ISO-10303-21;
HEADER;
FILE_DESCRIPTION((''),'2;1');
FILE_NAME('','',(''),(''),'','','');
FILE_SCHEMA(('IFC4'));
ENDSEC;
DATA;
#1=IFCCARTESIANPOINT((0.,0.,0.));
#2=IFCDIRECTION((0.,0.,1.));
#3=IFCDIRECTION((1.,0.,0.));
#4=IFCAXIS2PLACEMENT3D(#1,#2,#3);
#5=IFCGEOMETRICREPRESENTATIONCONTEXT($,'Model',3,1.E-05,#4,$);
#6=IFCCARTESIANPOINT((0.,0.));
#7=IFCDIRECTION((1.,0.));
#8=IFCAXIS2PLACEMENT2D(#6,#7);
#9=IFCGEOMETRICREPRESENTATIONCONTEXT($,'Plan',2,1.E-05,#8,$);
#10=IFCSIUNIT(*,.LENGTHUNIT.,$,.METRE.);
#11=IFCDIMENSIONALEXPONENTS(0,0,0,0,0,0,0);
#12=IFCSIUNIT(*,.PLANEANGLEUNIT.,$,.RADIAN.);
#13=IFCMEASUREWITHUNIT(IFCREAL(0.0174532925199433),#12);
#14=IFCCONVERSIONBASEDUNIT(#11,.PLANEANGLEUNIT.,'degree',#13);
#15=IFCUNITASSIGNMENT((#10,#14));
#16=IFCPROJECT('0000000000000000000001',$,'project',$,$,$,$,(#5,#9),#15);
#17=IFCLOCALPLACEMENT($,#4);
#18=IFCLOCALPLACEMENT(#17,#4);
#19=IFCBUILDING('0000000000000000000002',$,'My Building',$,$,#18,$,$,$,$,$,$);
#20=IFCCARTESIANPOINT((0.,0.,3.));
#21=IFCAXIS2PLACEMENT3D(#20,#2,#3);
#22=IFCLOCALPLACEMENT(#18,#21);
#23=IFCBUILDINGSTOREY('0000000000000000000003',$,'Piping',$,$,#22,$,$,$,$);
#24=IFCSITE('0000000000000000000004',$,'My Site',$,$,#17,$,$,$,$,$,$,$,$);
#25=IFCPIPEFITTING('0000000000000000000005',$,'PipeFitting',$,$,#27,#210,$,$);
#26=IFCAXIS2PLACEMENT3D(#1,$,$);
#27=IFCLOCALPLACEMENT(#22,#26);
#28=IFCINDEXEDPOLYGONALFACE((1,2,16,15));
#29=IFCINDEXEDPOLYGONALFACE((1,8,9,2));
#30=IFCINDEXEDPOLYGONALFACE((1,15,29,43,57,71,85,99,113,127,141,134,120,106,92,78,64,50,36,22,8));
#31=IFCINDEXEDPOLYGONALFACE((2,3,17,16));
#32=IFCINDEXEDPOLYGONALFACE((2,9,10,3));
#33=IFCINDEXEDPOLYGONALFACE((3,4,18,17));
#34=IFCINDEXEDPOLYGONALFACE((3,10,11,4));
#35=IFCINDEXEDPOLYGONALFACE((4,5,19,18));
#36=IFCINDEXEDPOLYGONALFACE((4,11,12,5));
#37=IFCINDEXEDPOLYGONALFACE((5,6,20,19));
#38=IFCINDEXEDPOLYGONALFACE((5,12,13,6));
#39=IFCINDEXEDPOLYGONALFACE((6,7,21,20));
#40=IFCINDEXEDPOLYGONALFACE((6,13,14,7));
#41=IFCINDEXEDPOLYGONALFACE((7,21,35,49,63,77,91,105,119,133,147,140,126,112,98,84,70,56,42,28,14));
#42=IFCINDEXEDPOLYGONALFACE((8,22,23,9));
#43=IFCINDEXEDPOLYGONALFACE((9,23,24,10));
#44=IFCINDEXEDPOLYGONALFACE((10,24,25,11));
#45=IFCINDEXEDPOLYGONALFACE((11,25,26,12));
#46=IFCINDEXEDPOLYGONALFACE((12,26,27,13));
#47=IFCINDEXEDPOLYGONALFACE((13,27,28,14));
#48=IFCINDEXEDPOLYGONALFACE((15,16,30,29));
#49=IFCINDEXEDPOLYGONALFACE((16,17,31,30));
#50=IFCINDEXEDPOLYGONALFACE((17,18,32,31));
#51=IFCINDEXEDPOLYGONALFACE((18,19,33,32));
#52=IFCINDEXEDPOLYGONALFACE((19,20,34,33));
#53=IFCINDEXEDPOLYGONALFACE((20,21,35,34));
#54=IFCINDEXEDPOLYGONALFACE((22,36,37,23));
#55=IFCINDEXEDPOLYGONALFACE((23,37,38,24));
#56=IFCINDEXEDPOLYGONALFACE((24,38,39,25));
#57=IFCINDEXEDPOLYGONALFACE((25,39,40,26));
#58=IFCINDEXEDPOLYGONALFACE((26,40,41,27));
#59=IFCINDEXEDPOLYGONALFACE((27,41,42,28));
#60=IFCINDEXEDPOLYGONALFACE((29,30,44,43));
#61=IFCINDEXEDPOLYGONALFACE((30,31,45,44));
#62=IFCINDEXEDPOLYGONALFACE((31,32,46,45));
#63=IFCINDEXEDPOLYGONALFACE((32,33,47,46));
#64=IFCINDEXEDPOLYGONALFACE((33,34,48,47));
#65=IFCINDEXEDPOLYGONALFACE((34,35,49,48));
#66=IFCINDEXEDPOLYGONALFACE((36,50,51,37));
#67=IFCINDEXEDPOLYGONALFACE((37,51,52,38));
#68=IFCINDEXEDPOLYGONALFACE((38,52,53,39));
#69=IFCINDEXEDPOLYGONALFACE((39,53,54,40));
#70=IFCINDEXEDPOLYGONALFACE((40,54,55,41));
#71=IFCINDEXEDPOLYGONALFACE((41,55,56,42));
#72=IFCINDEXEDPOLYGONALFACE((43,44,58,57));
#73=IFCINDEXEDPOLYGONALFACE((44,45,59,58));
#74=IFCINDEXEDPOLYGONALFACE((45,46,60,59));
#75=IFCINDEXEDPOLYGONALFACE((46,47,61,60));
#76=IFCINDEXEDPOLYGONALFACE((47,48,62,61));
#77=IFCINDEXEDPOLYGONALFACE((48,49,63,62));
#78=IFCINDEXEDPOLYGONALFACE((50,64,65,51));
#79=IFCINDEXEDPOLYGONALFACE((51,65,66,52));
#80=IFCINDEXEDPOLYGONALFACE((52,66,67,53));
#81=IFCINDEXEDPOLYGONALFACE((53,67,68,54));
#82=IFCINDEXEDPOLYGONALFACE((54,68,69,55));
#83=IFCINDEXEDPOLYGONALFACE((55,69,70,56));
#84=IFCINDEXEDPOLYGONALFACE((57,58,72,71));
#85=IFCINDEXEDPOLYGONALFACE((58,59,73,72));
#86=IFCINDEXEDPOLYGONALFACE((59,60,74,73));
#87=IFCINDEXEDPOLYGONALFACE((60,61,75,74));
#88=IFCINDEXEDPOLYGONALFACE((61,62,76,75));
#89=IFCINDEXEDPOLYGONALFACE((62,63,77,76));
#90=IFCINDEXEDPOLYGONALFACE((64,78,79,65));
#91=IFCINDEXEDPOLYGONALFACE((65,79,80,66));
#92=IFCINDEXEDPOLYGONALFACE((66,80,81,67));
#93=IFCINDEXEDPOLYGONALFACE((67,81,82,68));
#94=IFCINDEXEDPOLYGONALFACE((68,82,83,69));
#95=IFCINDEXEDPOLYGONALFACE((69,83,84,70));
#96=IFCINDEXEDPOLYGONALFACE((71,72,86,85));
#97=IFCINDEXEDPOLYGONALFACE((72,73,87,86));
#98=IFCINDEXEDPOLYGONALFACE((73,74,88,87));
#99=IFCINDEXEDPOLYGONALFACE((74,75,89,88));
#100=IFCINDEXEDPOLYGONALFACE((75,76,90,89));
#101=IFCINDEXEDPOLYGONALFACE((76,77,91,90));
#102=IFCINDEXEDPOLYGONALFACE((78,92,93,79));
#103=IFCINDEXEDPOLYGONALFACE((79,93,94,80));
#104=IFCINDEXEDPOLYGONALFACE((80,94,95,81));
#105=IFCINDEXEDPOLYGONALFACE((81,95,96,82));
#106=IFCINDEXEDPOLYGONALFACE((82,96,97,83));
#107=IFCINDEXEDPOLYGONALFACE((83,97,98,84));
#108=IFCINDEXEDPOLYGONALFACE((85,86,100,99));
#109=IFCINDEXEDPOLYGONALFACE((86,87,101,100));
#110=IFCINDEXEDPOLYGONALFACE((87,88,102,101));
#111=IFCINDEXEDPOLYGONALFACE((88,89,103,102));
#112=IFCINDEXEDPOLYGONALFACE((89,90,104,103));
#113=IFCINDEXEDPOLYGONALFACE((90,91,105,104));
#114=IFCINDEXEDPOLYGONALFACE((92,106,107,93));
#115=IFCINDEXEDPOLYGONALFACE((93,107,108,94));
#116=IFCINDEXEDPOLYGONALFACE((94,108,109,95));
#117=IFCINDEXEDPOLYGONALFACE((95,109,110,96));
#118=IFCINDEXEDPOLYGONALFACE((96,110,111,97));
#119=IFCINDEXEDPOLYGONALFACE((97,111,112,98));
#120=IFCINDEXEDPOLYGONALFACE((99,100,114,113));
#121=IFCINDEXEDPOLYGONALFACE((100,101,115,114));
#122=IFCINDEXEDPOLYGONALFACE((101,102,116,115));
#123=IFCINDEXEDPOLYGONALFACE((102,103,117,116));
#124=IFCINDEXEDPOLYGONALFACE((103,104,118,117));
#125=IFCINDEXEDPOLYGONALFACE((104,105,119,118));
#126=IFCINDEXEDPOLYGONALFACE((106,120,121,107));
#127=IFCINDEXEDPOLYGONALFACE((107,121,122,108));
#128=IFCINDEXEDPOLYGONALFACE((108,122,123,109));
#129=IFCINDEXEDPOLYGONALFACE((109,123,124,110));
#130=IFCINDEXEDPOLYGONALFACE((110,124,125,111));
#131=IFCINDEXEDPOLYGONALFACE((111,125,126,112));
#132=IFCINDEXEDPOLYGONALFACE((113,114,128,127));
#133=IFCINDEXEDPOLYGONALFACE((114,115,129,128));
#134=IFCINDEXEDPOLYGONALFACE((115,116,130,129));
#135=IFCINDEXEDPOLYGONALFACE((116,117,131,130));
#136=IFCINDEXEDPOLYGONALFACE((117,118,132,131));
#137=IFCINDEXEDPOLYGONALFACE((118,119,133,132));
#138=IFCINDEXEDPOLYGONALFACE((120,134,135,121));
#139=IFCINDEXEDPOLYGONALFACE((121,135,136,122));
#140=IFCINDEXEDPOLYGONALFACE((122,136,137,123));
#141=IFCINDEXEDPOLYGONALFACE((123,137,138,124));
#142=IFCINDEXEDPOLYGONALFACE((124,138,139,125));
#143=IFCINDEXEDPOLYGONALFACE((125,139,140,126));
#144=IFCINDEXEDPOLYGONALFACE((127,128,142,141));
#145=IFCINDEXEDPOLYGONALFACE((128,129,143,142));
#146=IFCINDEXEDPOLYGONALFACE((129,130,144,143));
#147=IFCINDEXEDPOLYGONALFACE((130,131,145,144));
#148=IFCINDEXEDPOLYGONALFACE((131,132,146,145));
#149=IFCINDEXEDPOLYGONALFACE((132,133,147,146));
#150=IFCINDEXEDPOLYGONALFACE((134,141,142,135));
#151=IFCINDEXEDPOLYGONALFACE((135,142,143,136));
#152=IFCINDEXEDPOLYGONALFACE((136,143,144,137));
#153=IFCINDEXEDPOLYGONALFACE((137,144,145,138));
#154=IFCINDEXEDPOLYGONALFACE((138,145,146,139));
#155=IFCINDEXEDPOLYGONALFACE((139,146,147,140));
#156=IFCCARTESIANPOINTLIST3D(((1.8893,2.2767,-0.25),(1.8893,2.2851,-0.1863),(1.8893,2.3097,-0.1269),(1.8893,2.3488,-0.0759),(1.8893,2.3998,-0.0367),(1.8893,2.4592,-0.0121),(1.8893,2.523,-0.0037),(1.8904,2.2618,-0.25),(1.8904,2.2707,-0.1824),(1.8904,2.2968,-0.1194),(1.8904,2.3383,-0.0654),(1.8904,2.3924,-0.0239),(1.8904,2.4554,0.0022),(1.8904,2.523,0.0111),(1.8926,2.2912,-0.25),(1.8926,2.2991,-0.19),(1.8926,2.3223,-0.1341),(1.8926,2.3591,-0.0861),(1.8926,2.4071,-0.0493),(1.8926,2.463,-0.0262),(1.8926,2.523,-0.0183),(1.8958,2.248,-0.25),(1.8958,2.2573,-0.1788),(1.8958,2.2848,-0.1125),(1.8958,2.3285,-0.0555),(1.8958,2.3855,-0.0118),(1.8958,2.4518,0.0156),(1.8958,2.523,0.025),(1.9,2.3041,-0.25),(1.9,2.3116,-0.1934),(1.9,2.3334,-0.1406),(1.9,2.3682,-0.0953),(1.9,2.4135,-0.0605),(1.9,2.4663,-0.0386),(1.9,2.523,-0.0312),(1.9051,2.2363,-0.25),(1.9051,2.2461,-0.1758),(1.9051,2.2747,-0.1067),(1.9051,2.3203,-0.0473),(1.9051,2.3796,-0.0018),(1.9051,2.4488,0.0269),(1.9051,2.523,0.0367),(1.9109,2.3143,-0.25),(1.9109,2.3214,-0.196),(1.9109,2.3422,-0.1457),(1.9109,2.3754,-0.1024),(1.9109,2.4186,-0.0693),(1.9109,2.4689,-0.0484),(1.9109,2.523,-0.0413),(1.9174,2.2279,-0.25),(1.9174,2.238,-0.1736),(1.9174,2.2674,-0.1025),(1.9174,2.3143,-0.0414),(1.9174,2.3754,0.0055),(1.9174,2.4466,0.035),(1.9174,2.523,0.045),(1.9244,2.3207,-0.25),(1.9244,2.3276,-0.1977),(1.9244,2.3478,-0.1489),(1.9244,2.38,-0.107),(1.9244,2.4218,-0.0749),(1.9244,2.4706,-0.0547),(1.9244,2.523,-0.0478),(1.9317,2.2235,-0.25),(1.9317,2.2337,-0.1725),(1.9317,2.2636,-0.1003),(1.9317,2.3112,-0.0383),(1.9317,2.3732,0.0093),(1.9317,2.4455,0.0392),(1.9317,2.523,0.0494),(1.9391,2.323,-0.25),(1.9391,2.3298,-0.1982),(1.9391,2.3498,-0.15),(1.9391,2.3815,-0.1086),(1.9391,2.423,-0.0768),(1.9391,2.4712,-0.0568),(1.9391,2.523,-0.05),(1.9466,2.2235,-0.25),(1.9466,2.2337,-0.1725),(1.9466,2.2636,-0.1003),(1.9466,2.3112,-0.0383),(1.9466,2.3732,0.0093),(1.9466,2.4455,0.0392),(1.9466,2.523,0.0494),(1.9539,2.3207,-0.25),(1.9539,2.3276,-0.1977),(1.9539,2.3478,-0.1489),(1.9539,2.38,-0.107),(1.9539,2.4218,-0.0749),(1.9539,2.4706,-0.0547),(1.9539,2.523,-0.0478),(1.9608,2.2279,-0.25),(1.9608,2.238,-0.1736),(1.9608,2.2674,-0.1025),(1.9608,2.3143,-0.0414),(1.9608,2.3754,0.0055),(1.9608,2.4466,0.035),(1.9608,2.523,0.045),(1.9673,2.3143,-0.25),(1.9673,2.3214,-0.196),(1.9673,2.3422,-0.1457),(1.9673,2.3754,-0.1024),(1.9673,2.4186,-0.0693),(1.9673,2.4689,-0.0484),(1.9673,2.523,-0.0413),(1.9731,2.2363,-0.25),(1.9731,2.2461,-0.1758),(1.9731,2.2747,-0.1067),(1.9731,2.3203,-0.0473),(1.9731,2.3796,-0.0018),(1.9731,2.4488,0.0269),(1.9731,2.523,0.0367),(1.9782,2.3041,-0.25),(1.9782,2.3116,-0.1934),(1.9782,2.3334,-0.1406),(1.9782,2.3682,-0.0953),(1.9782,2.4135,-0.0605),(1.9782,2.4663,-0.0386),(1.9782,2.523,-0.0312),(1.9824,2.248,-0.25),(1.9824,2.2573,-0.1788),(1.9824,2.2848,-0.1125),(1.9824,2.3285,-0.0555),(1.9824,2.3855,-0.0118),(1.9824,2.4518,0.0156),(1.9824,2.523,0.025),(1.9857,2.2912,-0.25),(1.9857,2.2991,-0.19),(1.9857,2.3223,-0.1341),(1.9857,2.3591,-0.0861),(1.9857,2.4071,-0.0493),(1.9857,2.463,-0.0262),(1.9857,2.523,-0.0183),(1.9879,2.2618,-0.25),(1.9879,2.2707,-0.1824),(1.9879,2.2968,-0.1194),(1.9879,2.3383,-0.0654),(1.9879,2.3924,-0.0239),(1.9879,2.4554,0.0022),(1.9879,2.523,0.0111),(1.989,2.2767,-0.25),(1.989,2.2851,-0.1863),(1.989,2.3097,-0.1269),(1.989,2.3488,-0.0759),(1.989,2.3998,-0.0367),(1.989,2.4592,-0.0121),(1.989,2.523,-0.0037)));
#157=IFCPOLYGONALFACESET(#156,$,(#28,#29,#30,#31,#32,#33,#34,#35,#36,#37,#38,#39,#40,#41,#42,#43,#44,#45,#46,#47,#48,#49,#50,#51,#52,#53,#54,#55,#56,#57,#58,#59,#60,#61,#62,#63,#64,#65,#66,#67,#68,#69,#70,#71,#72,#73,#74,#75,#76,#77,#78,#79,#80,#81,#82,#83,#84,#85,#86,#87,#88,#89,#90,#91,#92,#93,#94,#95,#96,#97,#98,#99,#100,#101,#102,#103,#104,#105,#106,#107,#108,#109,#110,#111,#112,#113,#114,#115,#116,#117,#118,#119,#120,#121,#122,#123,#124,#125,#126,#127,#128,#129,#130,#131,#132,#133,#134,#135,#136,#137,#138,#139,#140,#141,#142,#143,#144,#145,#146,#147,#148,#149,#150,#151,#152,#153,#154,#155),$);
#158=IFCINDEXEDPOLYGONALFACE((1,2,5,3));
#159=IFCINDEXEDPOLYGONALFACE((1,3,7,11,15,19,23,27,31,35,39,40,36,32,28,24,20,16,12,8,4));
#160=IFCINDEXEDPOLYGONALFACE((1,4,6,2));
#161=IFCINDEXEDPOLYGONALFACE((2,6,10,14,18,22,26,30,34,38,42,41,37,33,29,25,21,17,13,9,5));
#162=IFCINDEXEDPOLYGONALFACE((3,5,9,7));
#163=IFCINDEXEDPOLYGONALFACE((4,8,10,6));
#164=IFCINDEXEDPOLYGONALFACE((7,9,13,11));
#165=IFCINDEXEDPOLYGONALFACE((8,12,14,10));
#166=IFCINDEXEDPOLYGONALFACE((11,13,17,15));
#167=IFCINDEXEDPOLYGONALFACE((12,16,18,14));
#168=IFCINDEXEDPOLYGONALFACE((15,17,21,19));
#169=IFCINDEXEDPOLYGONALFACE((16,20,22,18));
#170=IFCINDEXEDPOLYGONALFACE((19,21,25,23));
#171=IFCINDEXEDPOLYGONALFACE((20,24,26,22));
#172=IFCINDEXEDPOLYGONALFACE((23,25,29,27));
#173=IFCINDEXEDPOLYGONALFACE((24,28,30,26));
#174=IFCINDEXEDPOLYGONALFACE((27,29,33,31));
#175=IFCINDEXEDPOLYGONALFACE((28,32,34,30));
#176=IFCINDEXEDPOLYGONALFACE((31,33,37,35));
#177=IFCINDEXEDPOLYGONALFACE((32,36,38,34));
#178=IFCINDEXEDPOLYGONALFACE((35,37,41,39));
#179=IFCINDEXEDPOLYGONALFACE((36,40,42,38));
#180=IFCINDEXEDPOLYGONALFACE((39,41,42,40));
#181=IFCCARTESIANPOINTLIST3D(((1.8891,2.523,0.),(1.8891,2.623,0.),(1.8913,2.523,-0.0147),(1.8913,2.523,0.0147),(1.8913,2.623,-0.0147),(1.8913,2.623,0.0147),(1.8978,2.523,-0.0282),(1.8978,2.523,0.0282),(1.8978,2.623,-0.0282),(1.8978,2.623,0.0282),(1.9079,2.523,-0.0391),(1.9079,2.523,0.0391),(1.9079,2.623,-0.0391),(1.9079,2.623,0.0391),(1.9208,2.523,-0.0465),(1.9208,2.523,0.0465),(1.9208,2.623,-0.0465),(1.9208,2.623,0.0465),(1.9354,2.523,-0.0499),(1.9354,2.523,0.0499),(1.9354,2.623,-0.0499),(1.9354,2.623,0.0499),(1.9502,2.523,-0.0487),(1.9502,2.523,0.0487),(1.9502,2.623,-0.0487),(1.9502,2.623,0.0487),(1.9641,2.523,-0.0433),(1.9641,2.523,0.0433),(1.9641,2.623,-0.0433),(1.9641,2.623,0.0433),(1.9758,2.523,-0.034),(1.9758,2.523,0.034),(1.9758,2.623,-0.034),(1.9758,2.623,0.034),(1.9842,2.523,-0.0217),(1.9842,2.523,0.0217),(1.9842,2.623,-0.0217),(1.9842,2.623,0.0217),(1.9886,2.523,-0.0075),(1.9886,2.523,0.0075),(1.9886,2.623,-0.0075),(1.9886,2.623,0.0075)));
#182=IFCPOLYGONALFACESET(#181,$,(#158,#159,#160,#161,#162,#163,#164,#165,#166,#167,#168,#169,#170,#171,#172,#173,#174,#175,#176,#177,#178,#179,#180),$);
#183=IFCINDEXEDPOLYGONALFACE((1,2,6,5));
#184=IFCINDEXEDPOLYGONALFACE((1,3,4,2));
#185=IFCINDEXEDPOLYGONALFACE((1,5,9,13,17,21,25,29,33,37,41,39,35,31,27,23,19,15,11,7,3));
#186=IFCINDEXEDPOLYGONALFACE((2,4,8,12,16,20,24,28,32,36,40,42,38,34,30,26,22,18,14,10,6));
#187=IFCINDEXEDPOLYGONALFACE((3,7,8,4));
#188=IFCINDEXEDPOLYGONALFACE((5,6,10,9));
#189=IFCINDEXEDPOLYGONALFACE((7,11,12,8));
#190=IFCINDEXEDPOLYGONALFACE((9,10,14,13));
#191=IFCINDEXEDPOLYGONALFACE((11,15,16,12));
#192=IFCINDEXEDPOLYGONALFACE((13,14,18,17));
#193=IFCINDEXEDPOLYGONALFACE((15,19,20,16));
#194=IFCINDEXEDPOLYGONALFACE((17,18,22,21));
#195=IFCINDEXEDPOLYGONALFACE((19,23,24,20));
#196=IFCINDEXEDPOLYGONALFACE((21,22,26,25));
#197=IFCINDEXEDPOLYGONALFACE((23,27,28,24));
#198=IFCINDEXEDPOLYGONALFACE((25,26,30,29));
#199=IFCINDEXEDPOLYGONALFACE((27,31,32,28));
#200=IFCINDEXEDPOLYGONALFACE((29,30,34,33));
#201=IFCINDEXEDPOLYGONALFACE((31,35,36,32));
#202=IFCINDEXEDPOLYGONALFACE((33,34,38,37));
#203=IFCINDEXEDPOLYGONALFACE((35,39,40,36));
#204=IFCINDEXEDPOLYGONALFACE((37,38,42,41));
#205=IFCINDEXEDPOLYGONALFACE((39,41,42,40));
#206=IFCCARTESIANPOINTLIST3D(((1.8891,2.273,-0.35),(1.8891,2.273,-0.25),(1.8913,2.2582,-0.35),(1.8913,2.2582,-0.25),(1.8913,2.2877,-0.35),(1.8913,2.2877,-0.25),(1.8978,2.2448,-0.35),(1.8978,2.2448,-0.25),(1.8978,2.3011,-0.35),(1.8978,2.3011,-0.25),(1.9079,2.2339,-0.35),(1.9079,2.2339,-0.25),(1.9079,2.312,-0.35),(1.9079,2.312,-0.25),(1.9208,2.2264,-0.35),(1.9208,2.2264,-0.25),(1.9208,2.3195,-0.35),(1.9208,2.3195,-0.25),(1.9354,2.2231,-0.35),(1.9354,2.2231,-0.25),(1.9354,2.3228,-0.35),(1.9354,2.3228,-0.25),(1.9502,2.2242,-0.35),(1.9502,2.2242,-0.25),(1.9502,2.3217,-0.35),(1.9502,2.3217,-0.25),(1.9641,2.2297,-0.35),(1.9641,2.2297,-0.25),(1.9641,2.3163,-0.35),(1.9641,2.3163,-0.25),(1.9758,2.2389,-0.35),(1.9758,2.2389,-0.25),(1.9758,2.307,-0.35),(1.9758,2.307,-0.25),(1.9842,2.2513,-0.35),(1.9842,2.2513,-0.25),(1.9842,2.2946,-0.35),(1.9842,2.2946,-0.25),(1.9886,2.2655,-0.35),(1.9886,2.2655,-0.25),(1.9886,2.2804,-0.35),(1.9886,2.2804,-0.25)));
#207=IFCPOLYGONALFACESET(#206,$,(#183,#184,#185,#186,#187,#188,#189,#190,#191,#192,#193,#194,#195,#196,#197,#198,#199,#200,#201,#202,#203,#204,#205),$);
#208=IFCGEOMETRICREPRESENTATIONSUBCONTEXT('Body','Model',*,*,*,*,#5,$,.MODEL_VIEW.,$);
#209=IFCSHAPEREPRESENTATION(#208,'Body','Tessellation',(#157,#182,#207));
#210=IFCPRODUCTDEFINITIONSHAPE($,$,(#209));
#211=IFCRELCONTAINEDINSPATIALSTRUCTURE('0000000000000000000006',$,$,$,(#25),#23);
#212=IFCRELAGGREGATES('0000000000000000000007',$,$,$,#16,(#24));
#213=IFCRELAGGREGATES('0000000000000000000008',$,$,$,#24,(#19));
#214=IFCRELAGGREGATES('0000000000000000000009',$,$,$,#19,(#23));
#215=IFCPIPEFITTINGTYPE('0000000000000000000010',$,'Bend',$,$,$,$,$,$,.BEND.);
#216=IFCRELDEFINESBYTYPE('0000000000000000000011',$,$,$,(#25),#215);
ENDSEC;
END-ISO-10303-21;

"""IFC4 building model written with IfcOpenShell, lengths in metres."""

from ifc_helpers import new_model, entity, si_unit, converted_unit, frame, origin_with_axes, origin_2d_with_axis, place, context, subcontext, project, spatial, circle, extrude, source, transform, mapped, type_object, type_shapes, element, save


model = new_model("IFC4")

# Units and contexts
model_context = context("Model", 3, precision=1e-05, world=origin_with_axes())
plan_context = context("Plan", 2, precision=1e-05, world=origin_2d_with_axis())
body_context = subcontext(model_context, "Body", "Model", "MODEL_VIEW")
ifc_project = project(units=[si_unit("LENGTHUNIT", "METRE"), converted_unit("PLANEANGLEUNIT", "degree", entity("IfcReal", 0.0174532925199433), si_unit("PLANEANGLEUNIT", "RADIAN"), dimensions=[0, 0, 0, 0, 0, 0, 0])], contexts=[model_context, plan_context])

# Site, building, storey
site_placement = place(None, origin_with_axes())
site = spatial("IfcSite", under=ifc_project, at=site_placement, Name="My Site")
building_placement = place(site_placement, origin_with_axes())
building = spatial("IfcBuilding", under=site, at=building_placement, Name="My Building")
storey_placement = place(building_placement, frame((0.0, 0.0, 3.0), z_axis=(0.0, 0.0, 1.0), x_axis=(1.0, 0.0, 0.0)))
storey = spatial("IfcBuildingStorey", under=building, at=storey_placement, Name="Piping")

# Pipe fitting
pipe_fitting_type = type_object("IfcPipeFittingType", Name="Bend", PredefinedType="BEND")
shared_shape = source(origin_with_axes(), body_context, "Body", "SolidModel", [
    entity("IfcSweptDiskSolid", entity("IfcIndexedPolyCurve", entity("IfcCartesianPointList3D", [[0.0, 0.0, -0.1], [0.0, -0.0732, -0.2768], [0.0, -0.25, -0.35]]), [entity("IfcArcIndex", [1, 2, 3])]), 0.05),
    extrude(circle(Radius=0.05), origin_with_axes(), (0.0, 0.0, -1.0), 0.1),
    extrude(circle(Radius=0.05), frame((0.0, -0.25, -0.35), z_axis=(0.0, -1.0, 0.0), x_axis=(1.0, 0.0, 0.0)), (0.0, 0.0, 1.0), 0.1),
])
type_shapes(pipe_fitting_type, [shared_shape])
for number, where, z_axis, x_axis, name in (
    (1, (1.9391, 2.623, 0.0), (0.0, 1.0, 0.0), (-1.0, 0.0, 0.0), "PipeFitting"),
):
    element("IfcPipeFitting", number, at=place(storey_placement, frame(where, z_axis=z_axis, x_axis=x_axis)), inside=storey, type_object=pipe_fitting_type, Name=name, context=body_context, shape_type="MappedRepresentation", body=[
        mapped(shared_shape, transform((0.0, 0.0, 0.0), x_axis=(1.0, 0.0, 0.0), y_axis=(0.0, 1.0, 0.0), z_axis=(0.0, 0.0, 1.0), scale=1.0)),
    ])

save(model, "model.ifc")
